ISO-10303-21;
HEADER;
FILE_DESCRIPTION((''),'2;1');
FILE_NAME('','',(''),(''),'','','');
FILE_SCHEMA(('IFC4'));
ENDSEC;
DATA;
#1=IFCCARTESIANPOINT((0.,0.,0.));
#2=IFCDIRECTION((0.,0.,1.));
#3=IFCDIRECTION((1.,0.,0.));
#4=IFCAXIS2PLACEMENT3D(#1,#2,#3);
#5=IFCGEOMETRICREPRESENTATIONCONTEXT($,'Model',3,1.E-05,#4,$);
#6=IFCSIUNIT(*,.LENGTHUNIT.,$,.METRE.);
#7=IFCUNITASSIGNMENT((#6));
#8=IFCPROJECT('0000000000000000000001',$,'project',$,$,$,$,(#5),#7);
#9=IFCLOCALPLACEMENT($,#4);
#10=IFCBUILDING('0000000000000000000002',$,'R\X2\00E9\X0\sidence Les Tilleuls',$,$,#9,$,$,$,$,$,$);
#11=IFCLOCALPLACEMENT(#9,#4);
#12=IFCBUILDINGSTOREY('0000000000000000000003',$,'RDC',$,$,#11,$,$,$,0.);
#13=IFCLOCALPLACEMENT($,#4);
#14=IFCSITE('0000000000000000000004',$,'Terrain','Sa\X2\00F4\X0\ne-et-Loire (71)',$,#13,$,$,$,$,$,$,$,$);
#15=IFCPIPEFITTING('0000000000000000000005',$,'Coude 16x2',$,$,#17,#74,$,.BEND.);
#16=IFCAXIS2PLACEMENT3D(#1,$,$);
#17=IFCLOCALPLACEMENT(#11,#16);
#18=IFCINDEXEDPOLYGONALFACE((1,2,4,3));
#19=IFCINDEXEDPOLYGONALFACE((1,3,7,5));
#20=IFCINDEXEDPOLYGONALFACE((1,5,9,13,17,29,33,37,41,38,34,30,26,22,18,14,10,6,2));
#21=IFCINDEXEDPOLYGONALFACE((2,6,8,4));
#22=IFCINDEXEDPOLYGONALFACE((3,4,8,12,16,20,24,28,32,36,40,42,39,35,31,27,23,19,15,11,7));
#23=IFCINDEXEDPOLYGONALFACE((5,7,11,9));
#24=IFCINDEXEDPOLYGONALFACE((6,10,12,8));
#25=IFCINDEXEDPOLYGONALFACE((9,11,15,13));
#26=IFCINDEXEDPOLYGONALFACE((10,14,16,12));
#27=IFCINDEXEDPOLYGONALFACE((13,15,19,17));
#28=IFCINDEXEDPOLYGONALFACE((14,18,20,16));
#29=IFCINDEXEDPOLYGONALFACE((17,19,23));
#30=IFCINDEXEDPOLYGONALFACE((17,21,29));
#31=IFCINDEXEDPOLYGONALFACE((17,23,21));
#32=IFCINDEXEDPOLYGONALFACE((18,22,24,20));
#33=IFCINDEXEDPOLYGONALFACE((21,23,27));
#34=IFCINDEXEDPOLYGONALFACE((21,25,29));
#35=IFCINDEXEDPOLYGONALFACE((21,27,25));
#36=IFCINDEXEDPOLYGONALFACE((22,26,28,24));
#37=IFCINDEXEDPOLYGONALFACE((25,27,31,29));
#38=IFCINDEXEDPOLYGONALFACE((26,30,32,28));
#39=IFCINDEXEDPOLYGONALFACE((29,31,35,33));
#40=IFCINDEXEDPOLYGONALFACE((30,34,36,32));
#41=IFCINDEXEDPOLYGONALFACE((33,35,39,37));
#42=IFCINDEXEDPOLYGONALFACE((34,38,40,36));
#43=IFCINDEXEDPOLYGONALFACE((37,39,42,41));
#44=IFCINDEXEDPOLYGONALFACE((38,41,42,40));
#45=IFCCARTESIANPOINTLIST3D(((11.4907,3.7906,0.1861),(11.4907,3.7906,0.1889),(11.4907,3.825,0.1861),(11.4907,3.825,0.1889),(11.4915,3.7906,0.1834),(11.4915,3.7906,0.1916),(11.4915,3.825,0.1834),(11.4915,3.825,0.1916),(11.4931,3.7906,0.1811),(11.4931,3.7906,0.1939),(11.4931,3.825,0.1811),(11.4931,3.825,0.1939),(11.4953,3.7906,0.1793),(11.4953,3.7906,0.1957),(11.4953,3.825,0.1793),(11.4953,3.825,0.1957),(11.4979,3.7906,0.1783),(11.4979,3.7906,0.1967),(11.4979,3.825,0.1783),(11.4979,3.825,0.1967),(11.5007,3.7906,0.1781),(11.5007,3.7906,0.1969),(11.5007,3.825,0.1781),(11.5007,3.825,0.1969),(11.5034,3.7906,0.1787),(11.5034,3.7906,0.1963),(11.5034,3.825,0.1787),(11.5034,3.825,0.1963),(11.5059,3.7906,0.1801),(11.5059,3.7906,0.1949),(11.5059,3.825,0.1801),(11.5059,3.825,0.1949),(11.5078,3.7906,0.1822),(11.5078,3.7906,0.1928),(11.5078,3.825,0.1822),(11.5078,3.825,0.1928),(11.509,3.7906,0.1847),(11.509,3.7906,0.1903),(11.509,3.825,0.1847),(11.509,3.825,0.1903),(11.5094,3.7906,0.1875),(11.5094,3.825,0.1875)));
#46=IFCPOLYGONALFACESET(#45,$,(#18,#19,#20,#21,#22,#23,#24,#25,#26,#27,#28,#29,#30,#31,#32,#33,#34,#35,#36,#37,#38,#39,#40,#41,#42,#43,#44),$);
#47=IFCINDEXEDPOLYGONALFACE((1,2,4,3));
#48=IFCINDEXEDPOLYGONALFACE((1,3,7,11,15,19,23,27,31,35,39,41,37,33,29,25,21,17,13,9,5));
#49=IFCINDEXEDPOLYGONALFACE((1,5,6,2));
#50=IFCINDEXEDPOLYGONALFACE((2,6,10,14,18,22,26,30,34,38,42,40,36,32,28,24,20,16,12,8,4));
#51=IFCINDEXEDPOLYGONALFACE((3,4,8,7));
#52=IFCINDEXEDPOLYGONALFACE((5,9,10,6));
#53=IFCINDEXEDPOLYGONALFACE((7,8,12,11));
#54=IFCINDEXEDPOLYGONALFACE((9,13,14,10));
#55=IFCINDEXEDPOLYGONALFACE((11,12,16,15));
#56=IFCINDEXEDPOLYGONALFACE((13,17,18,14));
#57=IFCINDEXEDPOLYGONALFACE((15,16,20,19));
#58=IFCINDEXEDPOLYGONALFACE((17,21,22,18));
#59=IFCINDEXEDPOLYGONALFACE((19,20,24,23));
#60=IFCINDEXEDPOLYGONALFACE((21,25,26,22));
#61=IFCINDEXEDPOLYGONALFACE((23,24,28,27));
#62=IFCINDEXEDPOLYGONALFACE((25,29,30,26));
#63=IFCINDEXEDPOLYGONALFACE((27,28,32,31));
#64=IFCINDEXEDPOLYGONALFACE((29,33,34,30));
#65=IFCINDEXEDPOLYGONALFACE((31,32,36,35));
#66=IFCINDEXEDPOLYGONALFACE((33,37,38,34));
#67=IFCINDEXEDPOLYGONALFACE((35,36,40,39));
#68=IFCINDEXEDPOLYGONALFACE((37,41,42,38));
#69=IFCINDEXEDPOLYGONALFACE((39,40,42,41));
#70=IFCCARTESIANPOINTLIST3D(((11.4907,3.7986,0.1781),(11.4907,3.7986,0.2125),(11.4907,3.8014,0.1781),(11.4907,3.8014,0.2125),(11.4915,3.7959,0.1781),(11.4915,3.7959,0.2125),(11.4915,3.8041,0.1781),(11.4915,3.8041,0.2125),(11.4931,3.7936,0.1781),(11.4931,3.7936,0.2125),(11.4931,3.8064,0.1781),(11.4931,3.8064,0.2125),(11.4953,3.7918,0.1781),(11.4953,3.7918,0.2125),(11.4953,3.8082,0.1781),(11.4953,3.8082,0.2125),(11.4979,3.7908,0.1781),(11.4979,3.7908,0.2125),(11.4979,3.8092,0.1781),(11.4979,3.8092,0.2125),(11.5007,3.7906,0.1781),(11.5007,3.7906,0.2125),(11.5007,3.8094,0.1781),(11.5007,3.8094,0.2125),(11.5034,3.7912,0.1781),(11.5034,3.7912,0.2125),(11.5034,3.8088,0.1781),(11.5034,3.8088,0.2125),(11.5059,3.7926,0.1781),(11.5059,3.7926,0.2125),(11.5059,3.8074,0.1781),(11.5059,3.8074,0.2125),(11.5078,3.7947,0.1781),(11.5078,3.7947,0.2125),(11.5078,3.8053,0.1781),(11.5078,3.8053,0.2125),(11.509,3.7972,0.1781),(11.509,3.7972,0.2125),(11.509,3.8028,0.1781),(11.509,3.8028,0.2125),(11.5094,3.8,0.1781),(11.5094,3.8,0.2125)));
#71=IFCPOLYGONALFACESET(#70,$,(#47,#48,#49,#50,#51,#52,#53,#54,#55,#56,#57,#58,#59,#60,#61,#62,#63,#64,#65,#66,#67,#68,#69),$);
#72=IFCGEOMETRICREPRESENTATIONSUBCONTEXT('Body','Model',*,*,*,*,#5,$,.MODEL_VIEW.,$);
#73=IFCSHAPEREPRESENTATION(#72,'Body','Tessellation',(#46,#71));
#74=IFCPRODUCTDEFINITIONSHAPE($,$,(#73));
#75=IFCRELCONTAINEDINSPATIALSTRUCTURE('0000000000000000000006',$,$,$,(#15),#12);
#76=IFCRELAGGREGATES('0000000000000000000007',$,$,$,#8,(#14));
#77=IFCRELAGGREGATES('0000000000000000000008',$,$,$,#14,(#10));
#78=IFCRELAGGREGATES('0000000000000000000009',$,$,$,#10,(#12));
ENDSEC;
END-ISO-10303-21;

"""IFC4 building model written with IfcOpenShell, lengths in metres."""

from ifc_helpers import new_model, si_unit, frame, origin_with_axes, place, context, subcontext, project, spatial, circle, extrude, element, save


model = new_model("IFC4")

# Units and contexts
model_context = context("Model", 3, precision=1e-05, world=origin_with_axes())
body_context = subcontext(model_context, "Body", "Model", "MODEL_VIEW")
ifc_project = project(units=[si_unit("LENGTHUNIT", "METRE")], contexts=[model_context])

# Site, building, storey
site_placement = place(None, origin_with_axes())
site = spatial("IfcSite", under=ifc_project, at=site_placement, Name="Terrain", Description="Saône-et-Loire (71)")
building_placement = place(None, origin_with_axes())
building = spatial("IfcBuilding", under=site, at=building_placement, Name="Résidence Les Tilleuls")
storey_placement = place(building_placement, origin_with_axes())
storey = spatial("IfcBuildingStorey", under=building, at=storey_placement, Name="RDC", Elevation=0.0)

# Pipe fitting
pipe_fitting_1_placement = place(storey_placement, frame((11.5, 3.8, 0.1875), z_axis=(0.0, 0.0, 1.0), x_axis=(1.0, 0.0, 0.0)))
element("IfcPipeFitting", 1, at=pipe_fitting_1_placement, inside=storey, Name="Coude 16x2", PredefinedType="BEND", context=body_context, shape_type="SweptSolid", body=[
    extrude(circle(Radius=0.0094), frame((0.0, -0.0094, 0.0), z_axis=(0.0, 1.0, 0.0), x_axis=(1.0, 0.0, 0.0)), (0.0, 0.0, 1.0), 0.0344),
    extrude(circle(Radius=0.0094), frame((0.0, 0.0, -0.0094), z_axis=(0.0, 0.0, 1.0), x_axis=(1.0, 0.0, 0.0)), (0.0, 0.0, 1.0), 0.0344),
])

save(model, "model.ifc")
